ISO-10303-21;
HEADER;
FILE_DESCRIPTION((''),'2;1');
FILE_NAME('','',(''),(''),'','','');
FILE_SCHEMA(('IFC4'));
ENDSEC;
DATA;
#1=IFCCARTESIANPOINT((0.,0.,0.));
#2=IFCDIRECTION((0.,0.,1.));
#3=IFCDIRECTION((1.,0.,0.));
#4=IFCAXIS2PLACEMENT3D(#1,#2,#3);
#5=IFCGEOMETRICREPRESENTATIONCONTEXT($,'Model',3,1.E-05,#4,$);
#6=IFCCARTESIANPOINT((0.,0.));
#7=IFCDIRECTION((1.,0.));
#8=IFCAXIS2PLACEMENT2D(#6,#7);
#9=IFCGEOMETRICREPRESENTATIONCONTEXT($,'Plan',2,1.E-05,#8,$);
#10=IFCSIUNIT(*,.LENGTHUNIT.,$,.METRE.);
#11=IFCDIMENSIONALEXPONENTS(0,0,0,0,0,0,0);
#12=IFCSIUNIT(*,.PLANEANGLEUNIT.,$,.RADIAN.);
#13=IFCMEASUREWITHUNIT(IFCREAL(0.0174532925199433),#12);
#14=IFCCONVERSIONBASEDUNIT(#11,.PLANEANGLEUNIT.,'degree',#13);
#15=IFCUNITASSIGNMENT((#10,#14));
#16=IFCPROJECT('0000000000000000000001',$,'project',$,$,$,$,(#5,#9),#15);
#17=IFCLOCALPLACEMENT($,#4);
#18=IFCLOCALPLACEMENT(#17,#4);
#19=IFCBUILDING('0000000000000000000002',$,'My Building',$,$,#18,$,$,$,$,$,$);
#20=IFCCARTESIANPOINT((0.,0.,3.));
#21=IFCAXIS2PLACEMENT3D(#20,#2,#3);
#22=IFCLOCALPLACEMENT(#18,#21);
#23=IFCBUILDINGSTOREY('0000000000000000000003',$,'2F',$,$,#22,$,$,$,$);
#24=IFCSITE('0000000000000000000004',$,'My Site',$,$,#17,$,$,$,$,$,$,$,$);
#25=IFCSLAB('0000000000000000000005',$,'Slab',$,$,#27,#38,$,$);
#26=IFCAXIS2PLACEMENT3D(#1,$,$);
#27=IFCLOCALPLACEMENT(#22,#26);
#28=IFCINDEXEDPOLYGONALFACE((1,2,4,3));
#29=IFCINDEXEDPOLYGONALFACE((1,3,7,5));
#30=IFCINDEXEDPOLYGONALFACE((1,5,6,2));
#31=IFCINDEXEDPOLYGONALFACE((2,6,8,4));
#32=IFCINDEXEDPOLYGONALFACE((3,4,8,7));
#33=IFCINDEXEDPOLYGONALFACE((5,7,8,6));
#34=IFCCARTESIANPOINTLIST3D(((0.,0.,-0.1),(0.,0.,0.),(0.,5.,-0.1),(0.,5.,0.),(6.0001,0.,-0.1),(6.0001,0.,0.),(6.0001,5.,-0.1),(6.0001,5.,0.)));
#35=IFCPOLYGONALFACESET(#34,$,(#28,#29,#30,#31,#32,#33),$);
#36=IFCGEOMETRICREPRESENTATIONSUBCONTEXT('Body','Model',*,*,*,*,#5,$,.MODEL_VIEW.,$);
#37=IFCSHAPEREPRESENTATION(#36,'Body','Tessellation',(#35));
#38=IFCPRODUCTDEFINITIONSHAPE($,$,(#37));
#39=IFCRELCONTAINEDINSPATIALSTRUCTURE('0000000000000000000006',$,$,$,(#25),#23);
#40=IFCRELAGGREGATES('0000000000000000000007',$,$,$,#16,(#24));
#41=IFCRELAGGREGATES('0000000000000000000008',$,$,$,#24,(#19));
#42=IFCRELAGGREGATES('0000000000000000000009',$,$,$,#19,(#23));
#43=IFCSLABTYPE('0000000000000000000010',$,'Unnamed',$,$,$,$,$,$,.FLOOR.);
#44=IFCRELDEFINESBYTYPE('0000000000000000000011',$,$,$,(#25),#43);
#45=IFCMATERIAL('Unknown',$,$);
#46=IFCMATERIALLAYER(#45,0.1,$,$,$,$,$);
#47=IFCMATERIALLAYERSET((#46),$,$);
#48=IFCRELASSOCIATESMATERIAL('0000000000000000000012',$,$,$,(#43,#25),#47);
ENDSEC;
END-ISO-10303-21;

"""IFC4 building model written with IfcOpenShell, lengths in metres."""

from ifc_helpers import new_model, entity, si_unit, converted_unit, frame, origin_with_axes, origin_2d_with_axis, place, context, subcontext, project, spatial, indexed_curve, outline, extrude, material, layer, layer_set, layer_usage, type_object, element, save


model = new_model("IFC4")

# Units and contexts
model_context = context("Model", 3, precision=1e-05, world=origin_with_axes())
plan_context = context("Plan", 2, precision=1e-05, world=origin_2d_with_axis())
body_context = subcontext(model_context, "Body", "Model", "MODEL_VIEW")
ifc_project = project(units=[si_unit("LENGTHUNIT", "METRE"), converted_unit("PLANEANGLEUNIT", "degree", entity("IfcReal", 0.0174532925199433), si_unit("PLANEANGLEUNIT", "RADIAN"), dimensions=[0, 0, 0, 0, 0, 0, 0])], contexts=[model_context, plan_context])

# Site, building, storey
site_placement = place(None, origin_with_axes())
site = spatial("IfcSite", under=ifc_project, at=site_placement, Name="My Site")
building_placement = place(site_placement, origin_with_axes())
building = spatial("IfcBuilding", under=site, at=building_placement, Name="My Building")
storey_placement = place(building_placement, frame((0.0, 0.0, 3.0), z_axis=(0.0, 0.0, 1.0), x_axis=(1.0, 0.0, 0.0)))
storey = spatial("IfcBuildingStorey", under=building, at=storey_placement, Name="2F")

# Slab
ifc_material = material(Name="Unknown")
ifc_layer = layer(ifc_material, 0.1)
ifc_layer_set = layer_set([ifc_layer])
ifc_layer_usage = layer_usage(ifc_layer_set, "AXIS3", "POSITIVE", -0.1)
slab_type = type_object("IfcSlabType", Name="Unnamed", PredefinedType="FLOOR", material=ifc_layer_set)
slab_placement = place(storey_placement, frame((0.0, 5.0, 0.0), z_axis=(0.0, 0.0, 1.0), x_axis=(1.0, 0.0, 0.0)))
element("IfcSlab", 1, at=slab_placement, inside=storey, type_object=slab_type, material=ifc_layer_usage, Name="Slab", context=body_context, shape_type="SweptSolid", body=[
    extrude(outline(indexed_curve([(0.0, 0.0), (6.0001, 0.0), (6.0001, -5.0), (0.0, -5.0), (0.0, 0.0)])), frame((0.0, 0.0, -0.1), z_axis=(0.0, 0.0, 1.0), x_axis=(1.0, 0.0, 0.0)), (0.0, 0.0, 1.0), 0.1),
])

save(model, "model.ifc")
